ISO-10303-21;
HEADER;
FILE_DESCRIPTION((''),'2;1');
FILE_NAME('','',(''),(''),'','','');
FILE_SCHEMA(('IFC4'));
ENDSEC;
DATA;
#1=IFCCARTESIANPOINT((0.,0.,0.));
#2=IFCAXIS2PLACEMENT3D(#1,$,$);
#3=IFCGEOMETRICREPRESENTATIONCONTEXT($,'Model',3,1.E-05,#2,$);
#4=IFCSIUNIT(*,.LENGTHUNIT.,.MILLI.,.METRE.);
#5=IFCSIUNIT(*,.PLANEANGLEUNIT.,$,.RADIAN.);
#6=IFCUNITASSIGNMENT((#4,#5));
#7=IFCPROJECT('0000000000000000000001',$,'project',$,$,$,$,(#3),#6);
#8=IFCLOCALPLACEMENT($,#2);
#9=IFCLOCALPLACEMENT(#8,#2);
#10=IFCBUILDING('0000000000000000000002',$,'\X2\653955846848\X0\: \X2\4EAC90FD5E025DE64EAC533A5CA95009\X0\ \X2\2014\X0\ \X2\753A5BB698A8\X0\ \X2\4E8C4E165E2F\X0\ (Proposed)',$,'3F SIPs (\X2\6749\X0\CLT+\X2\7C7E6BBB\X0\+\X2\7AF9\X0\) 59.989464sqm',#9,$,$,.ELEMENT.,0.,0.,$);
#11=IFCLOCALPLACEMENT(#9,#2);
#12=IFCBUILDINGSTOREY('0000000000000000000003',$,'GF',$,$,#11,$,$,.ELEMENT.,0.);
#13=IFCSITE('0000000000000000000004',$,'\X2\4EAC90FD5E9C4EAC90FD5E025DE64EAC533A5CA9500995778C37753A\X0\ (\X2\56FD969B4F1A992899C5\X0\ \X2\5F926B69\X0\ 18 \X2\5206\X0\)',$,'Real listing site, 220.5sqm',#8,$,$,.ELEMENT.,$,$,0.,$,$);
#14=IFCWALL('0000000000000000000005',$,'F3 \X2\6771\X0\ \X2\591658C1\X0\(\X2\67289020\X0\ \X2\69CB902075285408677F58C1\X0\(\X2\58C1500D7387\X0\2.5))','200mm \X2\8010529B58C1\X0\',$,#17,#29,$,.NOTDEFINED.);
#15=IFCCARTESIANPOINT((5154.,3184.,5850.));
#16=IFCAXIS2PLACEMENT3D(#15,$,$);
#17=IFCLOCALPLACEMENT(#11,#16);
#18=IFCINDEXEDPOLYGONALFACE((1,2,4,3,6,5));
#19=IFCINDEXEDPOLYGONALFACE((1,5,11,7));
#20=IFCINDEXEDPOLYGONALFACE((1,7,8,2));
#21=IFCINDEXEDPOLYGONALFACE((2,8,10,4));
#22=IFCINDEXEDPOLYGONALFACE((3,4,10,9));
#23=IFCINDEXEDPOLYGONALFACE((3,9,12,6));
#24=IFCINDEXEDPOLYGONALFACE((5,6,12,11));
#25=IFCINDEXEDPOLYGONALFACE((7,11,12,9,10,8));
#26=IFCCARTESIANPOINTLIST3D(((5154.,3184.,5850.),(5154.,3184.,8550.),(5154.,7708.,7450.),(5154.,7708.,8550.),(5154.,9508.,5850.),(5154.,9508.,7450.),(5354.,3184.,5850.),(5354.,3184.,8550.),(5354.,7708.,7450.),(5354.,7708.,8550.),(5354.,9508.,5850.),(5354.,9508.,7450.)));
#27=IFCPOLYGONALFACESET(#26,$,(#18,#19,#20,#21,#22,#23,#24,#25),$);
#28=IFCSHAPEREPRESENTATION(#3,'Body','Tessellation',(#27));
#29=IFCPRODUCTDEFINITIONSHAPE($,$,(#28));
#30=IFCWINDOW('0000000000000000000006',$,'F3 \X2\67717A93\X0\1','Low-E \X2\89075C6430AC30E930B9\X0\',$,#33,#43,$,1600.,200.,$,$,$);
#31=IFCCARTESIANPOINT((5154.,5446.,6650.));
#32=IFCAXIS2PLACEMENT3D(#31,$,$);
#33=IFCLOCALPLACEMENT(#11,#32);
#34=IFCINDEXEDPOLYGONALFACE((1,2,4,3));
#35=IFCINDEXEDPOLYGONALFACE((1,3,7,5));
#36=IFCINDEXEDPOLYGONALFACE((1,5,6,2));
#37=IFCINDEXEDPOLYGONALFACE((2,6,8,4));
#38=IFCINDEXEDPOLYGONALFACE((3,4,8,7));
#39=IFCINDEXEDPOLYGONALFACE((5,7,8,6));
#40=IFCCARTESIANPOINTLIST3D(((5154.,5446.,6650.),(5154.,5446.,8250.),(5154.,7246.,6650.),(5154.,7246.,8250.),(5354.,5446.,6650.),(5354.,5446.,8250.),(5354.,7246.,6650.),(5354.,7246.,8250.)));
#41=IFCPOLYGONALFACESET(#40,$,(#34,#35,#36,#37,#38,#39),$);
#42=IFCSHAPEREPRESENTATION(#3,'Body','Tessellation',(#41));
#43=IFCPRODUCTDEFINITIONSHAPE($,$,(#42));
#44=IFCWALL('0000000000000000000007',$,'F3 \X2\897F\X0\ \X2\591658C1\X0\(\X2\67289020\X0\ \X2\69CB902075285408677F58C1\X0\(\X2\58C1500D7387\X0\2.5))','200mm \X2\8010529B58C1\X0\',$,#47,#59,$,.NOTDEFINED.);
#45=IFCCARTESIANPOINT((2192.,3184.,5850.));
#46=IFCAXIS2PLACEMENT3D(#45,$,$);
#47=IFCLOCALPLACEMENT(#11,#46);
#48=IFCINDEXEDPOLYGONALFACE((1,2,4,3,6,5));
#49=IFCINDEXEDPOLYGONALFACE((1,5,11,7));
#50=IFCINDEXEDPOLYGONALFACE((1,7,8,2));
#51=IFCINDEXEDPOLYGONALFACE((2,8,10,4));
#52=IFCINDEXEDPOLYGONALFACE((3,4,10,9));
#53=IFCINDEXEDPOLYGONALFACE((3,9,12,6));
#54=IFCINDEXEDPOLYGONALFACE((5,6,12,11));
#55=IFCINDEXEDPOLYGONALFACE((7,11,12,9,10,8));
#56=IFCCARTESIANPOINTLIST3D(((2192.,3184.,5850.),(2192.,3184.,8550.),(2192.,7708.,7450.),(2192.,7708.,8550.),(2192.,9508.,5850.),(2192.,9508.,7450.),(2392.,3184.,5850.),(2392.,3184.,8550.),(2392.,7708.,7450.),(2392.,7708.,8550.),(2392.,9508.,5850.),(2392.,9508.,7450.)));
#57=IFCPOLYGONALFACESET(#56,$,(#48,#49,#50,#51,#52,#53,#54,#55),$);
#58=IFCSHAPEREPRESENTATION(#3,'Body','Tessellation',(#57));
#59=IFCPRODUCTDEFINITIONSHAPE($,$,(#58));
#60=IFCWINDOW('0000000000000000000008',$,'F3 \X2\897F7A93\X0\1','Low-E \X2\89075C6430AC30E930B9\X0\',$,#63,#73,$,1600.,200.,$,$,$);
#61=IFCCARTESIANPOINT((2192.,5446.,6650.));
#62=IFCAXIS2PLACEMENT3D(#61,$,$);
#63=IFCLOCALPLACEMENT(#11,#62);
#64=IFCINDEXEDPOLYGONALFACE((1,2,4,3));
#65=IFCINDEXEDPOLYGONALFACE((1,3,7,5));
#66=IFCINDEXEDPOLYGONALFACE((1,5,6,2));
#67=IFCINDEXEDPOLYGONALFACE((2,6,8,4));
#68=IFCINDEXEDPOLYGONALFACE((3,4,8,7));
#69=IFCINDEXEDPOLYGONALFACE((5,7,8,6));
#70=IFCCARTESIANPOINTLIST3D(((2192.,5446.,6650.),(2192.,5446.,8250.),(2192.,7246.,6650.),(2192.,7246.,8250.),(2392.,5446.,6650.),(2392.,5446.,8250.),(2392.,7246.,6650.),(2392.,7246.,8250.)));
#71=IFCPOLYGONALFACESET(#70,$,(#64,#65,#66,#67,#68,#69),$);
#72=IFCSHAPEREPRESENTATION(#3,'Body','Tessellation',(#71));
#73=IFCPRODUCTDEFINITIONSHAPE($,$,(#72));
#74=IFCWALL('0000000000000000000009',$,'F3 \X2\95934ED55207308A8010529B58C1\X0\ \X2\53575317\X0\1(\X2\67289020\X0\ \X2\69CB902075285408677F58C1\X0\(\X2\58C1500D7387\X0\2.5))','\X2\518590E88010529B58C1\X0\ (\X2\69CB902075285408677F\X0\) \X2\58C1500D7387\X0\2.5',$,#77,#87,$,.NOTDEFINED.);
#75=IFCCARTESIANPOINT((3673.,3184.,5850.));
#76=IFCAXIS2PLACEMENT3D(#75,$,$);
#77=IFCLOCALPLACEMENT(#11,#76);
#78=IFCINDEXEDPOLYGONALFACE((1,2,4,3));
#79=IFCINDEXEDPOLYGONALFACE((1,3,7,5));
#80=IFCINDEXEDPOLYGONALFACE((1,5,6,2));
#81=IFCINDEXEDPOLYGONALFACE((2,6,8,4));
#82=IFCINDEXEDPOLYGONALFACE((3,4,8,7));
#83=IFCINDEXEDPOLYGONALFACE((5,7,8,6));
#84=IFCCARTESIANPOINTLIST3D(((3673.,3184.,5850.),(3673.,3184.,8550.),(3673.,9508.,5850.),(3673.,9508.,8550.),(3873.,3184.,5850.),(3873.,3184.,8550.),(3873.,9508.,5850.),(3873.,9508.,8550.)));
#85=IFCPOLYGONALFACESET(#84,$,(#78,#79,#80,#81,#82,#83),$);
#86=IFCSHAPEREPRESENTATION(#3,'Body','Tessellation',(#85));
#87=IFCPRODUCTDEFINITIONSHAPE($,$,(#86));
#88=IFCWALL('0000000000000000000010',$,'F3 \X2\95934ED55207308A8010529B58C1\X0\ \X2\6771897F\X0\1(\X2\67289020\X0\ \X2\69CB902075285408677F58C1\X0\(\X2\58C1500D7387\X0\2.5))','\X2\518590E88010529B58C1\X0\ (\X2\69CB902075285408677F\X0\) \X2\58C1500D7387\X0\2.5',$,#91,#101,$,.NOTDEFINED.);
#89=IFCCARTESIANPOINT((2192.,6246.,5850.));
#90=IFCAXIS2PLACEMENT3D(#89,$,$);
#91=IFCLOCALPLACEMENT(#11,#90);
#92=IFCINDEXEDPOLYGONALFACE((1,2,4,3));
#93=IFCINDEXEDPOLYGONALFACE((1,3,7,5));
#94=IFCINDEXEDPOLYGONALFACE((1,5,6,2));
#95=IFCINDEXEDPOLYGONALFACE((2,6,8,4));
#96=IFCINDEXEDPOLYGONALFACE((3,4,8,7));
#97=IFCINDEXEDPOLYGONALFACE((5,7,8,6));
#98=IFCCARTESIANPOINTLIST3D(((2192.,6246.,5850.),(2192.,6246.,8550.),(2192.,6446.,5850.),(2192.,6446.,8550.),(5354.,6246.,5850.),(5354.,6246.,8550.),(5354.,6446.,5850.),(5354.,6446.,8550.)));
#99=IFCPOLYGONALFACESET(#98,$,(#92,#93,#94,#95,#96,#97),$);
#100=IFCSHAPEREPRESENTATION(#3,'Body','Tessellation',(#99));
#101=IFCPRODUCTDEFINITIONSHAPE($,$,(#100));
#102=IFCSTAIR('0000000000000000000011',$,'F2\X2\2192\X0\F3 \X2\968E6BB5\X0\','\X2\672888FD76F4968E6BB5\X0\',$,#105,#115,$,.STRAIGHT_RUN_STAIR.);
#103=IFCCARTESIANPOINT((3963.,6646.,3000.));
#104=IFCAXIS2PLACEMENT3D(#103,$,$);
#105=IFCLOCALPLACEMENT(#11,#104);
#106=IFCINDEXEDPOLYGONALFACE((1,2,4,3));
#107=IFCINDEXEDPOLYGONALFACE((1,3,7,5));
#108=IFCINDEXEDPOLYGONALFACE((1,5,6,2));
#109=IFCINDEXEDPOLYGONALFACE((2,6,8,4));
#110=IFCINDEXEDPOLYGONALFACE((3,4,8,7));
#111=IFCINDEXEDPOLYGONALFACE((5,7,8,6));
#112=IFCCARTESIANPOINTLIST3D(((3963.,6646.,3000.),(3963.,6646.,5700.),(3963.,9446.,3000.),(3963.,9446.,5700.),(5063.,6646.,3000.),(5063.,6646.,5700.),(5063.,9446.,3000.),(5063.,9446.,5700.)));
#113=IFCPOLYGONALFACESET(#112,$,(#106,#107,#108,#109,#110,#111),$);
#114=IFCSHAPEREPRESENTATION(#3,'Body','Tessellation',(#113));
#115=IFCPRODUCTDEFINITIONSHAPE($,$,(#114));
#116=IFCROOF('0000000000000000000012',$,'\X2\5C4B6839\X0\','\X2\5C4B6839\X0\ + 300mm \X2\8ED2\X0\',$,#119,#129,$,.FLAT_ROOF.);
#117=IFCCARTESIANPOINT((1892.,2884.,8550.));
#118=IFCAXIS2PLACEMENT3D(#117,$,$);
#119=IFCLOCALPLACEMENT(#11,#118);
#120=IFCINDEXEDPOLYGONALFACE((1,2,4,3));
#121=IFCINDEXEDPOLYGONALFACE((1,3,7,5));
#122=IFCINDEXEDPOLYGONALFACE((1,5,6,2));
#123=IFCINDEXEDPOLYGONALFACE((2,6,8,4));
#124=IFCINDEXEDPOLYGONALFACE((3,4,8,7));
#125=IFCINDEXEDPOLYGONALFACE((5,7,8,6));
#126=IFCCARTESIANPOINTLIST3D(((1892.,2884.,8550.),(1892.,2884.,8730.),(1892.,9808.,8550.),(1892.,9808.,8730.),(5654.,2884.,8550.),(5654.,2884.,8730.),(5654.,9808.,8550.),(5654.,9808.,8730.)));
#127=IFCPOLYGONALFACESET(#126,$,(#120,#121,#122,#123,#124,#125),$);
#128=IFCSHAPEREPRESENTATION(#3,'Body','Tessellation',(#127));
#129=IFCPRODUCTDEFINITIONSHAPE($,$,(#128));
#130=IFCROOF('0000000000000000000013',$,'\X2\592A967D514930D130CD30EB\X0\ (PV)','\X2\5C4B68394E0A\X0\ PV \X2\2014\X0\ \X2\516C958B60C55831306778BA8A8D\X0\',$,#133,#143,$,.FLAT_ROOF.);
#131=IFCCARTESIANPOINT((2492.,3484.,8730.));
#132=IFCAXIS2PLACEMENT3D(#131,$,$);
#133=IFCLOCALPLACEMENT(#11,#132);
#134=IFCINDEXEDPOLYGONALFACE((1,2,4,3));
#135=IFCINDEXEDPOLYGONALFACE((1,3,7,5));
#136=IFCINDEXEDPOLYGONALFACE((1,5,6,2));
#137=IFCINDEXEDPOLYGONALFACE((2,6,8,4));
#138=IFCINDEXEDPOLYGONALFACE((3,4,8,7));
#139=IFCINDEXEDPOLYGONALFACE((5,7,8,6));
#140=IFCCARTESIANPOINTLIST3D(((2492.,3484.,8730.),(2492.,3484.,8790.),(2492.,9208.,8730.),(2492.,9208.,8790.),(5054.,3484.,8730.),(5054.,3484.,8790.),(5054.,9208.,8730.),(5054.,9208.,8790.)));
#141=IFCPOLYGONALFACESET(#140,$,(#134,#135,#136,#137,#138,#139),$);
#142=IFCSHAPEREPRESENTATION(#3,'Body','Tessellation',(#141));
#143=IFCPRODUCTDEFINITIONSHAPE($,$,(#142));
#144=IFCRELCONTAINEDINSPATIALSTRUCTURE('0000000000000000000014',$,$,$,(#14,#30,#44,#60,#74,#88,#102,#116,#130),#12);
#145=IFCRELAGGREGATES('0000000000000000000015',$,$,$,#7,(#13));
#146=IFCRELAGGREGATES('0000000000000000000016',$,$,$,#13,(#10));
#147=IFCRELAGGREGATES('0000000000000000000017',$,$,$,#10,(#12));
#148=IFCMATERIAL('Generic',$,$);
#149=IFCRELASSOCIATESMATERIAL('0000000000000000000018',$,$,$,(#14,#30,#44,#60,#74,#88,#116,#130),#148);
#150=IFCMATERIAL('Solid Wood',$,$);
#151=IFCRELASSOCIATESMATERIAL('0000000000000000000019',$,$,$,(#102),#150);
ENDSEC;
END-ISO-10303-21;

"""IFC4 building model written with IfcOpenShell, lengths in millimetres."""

from ifc_helpers import new_model, si_unit, frame, frame_2d, origin, place, context, project, spatial, rectangle, extrude, material, element, fill, save


model = new_model("IFC4")

# Units and contexts
model_context = context("Model", 3, precision=1e-05, world=origin())
ifc_project = project(units=[si_unit("LENGTHUNIT", "METRE", prefix="MILLI"), si_unit("PLANEANGLEUNIT", "RADIAN")], contexts=[model_context])

# Site, building, storey
site_placement = place(None, origin())
site = spatial("IfcSite", under=ifc_project, at=site_placement, Name="京都府京都市左京区岩倉長谷町 (国際会館駅 徒歩 18 分)", ObjectType="Real listing site, 220.5sqm", CompositionType="ELEMENT", RefElevation=0.0)
building_placement = place(site_placement, origin())
building = spatial("IfcBuilding", under=site, at=building_placement, Name="改善案: 京都市左京区岩倉 — 町家風 二世帯 (Proposed)", ObjectType="3F SIPs (杉CLT+籾殻+竹) 59.989464sqm", CompositionType="ELEMENT", ElevationOfRefHeight=0.0, ElevationOfTerrain=0.0)
storey_placement = place(building_placement, origin())
storey = spatial("IfcBuildingStorey", under=building, at=storey_placement, Name="GF", CompositionType="ELEMENT", Elevation=0.0)

# Shared definitions
ifc_material_1 = material(Name="Generic")

# Walls, openings, windows
wall_1_placement = place(storey_placement, frame((5154.0, 3184.0, 5850.0)))
wall_1 = element("IfcWall", 1, at=wall_1_placement, inside=storey, material=ifc_material_1, Name="F3 東 外壁(木造 構造用合板壁(壁倍率2.5))", Description="200mm 耐力壁", PredefinedType="NOTDEFINED", context=model_context, shape_type="SweptSolid", body=[
    extrude(rectangle(XDim=200.0, YDim=6324.0, at=frame_2d((100.0, 3162.0))), frame((5154.0, 3184.0, 5850.0)), (0.0, 0.0, 1.0), 2700.0),
])
opening_1_placement = place(storey_placement, frame((5154.0, 5446.0, 6650.0)))
opening_1 = element("IfcOpeningElement", 2, at=opening_1_placement, cuts=wall_1, PredefinedType="NOTDEFINED", context=model_context, shape_type="SweptSolid", body=[
    extrude(rectangle(XDim=200.0, YDim=1800.0, at=frame_2d((100.0, 900.0))), frame((5154.0, 5446.0, 6650.0)), (0.0, 0.0, 1.0), 1600.0),
])
window_1_placement = place(storey_placement, frame((5154.0, 5446.0, 6650.0)))
window_1 = element("IfcWindow", 3, at=window_1_placement, inside=storey, material=ifc_material_1, Name="F3 東窓1", Description="Low-E 複層ガラス", OverallHeight=1600.0, OverallWidth=200.0, context=model_context, shape_type="SweptSolid", body=[
    extrude(rectangle(XDim=200.0, YDim=1800.0, at=frame_2d((100.0, 900.0))), frame((5154.0, 5446.0, 6650.0)), (0.0, 0.0, 1.0), 1600.0),
])
fill(opening_1, window_1)
wall_2_placement = place(storey_placement, frame((2192.0, 3184.0, 5850.0)))
wall_2 = element("IfcWall", 4, at=wall_2_placement, inside=storey, material=ifc_material_1, Name="F3 西 外壁(木造 構造用合板壁(壁倍率2.5))", Description="200mm 耐力壁", PredefinedType="NOTDEFINED", context=model_context, shape_type="SweptSolid", body=[
    extrude(rectangle(XDim=200.0, YDim=6324.0, at=frame_2d((100.0, 3162.0))), frame((2192.0, 3184.0, 5850.0)), (0.0, 0.0, 1.0), 2700.0),
])
opening_2_placement = place(storey_placement, frame((2192.0, 5446.0, 6650.0)))
opening_2 = element("IfcOpeningElement", 5, at=opening_2_placement, cuts=wall_2, PredefinedType="NOTDEFINED", context=model_context, shape_type="SweptSolid", body=[
    extrude(rectangle(XDim=200.0, YDim=1800.0, at=frame_2d((100.0, 900.0))), frame((2192.0, 5446.0, 6650.0)), (0.0, 0.0, 1.0), 1600.0),
])
window_2_placement = place(storey_placement, frame((2192.0, 5446.0, 6650.0)))
window_2 = element("IfcWindow", 6, at=window_2_placement, inside=storey, material=ifc_material_1, Name="F3 西窓1", Description="Low-E 複層ガラス", OverallHeight=1600.0, OverallWidth=200.0, context=model_context, shape_type="SweptSolid", body=[
    extrude(rectangle(XDim=200.0, YDim=1800.0, at=frame_2d((100.0, 900.0))), frame((2192.0, 5446.0, 6650.0)), (0.0, 0.0, 1.0), 1600.0),
])
fill(opening_2, window_2)

# Walls
wall_3_placement = place(storey_placement, frame((3673.0, 3184.0, 5850.0)))
element("IfcWall", 7, at=wall_3_placement, inside=storey, material=ifc_material_1, Name="F3 間仕切り耐力壁 南北1(木造 構造用合板壁(壁倍率2.5))", Description="内部耐力壁 (構造用合板) 壁倍率2.5", PredefinedType="NOTDEFINED", context=model_context, shape_type="SweptSolid", body=[
    extrude(rectangle(XDim=200.0, YDim=6324.0, at=frame_2d((100.0, 3162.0))), frame((3673.0, 3184.0, 5850.0)), (0.0, 0.0, 1.0), 2700.0),
])
wall_4_placement = place(storey_placement, frame((2192.0, 6246.0, 5850.0)))
element("IfcWall", 8, at=wall_4_placement, inside=storey, material=ifc_material_1, Name="F3 間仕切り耐力壁 東西1(木造 構造用合板壁(壁倍率2.5))", Description="内部耐力壁 (構造用合板) 壁倍率2.5", PredefinedType="NOTDEFINED", context=model_context, shape_type="SweptSolid", body=[
    extrude(rectangle(XDim=3162.0, YDim=200.0, at=frame_2d((1581.0, 100.0))), frame((2192.0, 6246.0, 5850.0)), (0.0, 0.0, 1.0), 2700.0),
])

# Stair
ifc_material_2 = material(Name="Solid Wood")
stair_placement = place(storey_placement, frame((3963.0, 6646.0, 3000.0)))
element("IfcStair", 9, at=stair_placement, inside=storey, material=ifc_material_2, Name="F2→F3 階段", Description="木製直階段", PredefinedType="STRAIGHT_RUN_STAIR", context=model_context, shape_type="SweptSolid", body=[
    extrude(rectangle(XDim=1100.0, YDim=2800.0, at=frame_2d((550.0, 1400.0))), frame((3963.0, 6646.0, 3000.0)), (0.0, 0.0, 1.0), 2700.0),
])

# Roofs
roof_1_placement = place(storey_placement, frame((1892.0, 2884.0, 8550.0)))
element("IfcRoof", 10, at=roof_1_placement, inside=storey, material=ifc_material_1, Name="屋根", Description="屋根 + 300mm 軒", PredefinedType="FLAT_ROOF", context=model_context, shape_type="SweptSolid", body=[
    extrude(rectangle(XDim=3762.0, YDim=6924.0, at=frame_2d((1881.0, 3462.0))), frame((1892.0, 2884.0, 8550.0)), (0.0, 0.0, 1.0), 180.0),
])
roof_2_placement = place(storey_placement, frame((2492.0, 3484.0, 8730.0)))
element("IfcRoof", 11, at=roof_2_placement, inside=storey, material=ifc_material_1, Name="太陽光パネル (PV)", Description="屋根上 PV — 公開情報で確認", PredefinedType="FLAT_ROOF", context=model_context, shape_type="SweptSolid", body=[
    extrude(rectangle(XDim=2562.0, YDim=5724.0, at=frame_2d((1281.0, 2862.0))), frame((2492.0, 3484.0, 8730.0)), (0.0, 0.0, 1.0), 60.0),
])

save(model, "model.ifc")
